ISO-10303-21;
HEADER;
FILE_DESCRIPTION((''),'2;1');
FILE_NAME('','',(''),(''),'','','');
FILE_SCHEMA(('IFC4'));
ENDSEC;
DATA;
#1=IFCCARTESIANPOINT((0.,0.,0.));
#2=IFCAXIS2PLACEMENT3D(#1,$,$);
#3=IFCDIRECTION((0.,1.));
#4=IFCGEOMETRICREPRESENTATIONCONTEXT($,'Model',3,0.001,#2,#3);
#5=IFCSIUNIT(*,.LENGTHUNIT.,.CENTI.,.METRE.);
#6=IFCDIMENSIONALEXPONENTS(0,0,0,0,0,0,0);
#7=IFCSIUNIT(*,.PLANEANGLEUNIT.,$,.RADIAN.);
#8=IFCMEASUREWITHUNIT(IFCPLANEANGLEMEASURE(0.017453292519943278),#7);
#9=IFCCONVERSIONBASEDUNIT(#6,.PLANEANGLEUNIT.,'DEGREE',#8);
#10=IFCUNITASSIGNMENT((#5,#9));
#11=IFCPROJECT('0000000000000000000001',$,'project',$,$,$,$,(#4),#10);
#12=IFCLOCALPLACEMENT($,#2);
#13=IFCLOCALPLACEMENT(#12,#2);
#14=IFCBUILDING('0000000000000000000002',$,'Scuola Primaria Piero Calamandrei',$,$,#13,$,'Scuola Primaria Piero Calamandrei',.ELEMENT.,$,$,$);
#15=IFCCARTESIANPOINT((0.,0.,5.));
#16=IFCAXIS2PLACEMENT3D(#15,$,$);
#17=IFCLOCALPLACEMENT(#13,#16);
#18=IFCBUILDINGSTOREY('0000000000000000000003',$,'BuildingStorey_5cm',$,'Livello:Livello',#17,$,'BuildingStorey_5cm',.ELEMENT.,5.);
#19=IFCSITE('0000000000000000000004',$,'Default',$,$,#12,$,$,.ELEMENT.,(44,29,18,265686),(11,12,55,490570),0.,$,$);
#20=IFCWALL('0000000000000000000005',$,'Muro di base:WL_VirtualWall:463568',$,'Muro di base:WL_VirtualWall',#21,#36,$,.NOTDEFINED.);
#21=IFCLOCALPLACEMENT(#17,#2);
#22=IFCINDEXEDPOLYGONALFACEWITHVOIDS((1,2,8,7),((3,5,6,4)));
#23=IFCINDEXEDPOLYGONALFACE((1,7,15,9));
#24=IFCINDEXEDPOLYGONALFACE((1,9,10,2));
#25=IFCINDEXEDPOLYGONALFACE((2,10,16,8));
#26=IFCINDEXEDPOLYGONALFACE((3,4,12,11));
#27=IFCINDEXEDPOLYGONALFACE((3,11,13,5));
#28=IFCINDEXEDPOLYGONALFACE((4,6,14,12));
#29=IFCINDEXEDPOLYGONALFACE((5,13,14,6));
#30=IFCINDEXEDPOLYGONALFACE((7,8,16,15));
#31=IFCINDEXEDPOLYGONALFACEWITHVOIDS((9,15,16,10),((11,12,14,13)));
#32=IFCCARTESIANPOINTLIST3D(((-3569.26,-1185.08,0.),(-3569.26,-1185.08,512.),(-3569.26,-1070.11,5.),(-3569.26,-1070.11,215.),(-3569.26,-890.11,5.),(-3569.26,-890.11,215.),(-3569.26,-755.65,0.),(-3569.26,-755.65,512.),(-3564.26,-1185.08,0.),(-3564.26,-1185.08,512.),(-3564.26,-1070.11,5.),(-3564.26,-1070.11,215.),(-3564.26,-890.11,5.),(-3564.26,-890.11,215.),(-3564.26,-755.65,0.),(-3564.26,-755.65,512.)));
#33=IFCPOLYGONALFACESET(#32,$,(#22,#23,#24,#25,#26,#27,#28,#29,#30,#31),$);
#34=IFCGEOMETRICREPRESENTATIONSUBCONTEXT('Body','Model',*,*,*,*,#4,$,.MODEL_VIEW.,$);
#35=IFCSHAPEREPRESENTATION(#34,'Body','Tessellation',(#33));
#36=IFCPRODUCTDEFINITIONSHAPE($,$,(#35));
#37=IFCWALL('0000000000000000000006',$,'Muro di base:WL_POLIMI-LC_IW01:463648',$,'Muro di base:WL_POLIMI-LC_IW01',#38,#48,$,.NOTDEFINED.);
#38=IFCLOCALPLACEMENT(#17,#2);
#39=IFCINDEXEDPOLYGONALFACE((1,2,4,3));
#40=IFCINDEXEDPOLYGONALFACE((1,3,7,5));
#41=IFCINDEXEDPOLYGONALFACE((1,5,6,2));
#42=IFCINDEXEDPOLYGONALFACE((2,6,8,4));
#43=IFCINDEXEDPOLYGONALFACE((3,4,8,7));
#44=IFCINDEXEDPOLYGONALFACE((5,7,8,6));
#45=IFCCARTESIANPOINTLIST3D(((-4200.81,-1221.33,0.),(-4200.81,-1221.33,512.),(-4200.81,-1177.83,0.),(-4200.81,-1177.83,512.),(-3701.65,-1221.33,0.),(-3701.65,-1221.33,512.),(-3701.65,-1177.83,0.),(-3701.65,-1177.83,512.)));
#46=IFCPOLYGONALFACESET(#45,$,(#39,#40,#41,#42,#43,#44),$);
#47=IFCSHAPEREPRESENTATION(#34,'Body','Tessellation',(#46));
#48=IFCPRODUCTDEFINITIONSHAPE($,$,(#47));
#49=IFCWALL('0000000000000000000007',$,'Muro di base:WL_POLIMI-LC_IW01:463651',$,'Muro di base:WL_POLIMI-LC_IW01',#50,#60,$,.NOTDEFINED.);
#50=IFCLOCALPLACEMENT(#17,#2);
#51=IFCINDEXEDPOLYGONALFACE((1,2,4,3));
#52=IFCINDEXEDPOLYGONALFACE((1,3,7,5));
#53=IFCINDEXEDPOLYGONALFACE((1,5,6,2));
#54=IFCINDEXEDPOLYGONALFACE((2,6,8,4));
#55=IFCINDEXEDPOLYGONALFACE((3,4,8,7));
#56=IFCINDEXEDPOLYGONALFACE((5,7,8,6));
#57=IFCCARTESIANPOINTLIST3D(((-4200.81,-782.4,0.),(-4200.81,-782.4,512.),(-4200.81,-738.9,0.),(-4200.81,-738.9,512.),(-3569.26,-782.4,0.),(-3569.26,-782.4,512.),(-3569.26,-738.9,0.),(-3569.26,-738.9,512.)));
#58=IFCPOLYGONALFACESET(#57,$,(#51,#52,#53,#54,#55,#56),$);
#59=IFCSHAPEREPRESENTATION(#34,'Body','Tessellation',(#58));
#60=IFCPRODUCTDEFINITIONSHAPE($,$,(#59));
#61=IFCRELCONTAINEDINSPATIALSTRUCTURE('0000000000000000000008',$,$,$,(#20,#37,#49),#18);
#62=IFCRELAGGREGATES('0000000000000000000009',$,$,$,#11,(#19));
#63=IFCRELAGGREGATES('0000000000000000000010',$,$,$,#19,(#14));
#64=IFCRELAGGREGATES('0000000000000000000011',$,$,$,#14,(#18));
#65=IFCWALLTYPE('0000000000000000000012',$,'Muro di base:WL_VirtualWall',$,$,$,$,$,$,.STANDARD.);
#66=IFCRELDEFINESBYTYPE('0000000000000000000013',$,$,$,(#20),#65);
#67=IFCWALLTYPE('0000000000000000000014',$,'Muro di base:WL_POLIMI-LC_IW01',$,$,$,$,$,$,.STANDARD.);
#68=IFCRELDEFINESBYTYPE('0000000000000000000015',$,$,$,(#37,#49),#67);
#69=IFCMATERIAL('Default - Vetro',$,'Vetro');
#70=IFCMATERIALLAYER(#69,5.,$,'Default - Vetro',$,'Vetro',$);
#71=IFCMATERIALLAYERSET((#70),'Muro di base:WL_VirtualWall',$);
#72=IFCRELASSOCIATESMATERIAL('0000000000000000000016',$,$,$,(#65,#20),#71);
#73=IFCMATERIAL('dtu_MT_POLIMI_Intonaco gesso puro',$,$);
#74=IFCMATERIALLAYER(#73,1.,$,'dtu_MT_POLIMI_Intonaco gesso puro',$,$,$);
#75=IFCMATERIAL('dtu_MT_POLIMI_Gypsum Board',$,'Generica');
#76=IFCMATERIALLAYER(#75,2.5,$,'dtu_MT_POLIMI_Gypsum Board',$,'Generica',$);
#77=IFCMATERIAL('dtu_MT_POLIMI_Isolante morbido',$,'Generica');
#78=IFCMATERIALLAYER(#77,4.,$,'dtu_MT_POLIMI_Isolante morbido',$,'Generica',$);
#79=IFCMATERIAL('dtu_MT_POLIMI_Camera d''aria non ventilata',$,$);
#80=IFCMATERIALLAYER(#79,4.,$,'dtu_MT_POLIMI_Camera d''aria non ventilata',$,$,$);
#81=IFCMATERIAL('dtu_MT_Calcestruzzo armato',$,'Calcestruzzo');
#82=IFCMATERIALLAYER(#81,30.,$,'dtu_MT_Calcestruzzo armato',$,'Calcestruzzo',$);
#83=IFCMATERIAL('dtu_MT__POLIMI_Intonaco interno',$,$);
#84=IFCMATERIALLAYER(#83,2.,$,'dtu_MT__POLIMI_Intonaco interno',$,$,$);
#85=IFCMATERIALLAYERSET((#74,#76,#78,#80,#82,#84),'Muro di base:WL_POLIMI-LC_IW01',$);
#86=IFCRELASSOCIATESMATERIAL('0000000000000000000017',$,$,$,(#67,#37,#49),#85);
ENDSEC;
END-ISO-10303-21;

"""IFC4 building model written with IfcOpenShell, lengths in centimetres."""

from ifc_helpers import new_model, entity, si_unit, converted_unit, direction, frame, frame_2d, origin, place, context, subcontext, project, spatial, rectangle, extrude, material, layer, layer_set, layer_usage, type_object, element, save


model = new_model("IFC4")

# Units and contexts
model_context = context("Model", 3, precision=0.001, world=origin(), true_north=direction((0.0, 1.0)))
body_context = subcontext(model_context, "Body", "Model", "MODEL_VIEW")
ifc_project = project(units=[si_unit("LENGTHUNIT", "METRE", prefix="CENTI"), converted_unit("PLANEANGLEUNIT", "DEGREE", entity("IfcPlaneAngleMeasure", 0.017453292519943278), si_unit("PLANEANGLEUNIT", "RADIAN"), dimensions=[0, 0, 0, 0, 0, 0, 0])], contexts=[model_context])

# Site, building, storey
site_placement = place(None, origin())
site = spatial("IfcSite", under=ifc_project, at=site_placement, Name="Default", CompositionType="ELEMENT", RefLatitude=(44, 29, 18, 265686), RefLongitude=(11, 12, 55, 490570), RefElevation=0.0)
building_placement = place(site_placement, origin())
building = spatial("IfcBuilding", under=site, at=building_placement, Name="Scuola Primaria Piero Calamandrei", LongName="Scuola Primaria Piero Calamandrei", CompositionType="ELEMENT")
storey_placement = place(building_placement, frame((0.0, 0.0, 5.0)))
storey = spatial("IfcBuildingStorey", under=building, at=storey_placement, Name="BuildingStorey_5cm", ObjectType="Livello:Livello", LongName="BuildingStorey_5cm", CompositionType="ELEMENT", Elevation=5.0)

# Shared definitions
ifc_material_1 = material(Name="dtu_MT__POLIMI_Intonaco interno")

# Shared definitions
ifc_material_2 = material(Name="dtu_MT_POLIMI_Intonaco gesso puro")

# Shared definitions
ifc_material_3 = material(Name="Default - Vetro", Category="Vetro")

# Shared definitions
ifc_material_4 = material(Name="dtu_MT_POLIMI_Isolante morbido", Category="Generica")
ifc_material_5 = material(Name="dtu_MT_POLIMI_Gypsum Board", Category="Generica")
ifc_material_6 = material(Name="dtu_MT_POLIMI_Camera d'aria non ventilata")

# Wall, opening
ifc_layer_1 = layer(ifc_material_3, 5.0, Name="Default - Vetro", Category="Vetro")
ifc_layer_set_1 = layer_set([ifc_layer_1], Name="Muro di base:WL_VirtualWall")
ifc_layer_usage_1 = layer_usage(ifc_layer_set_1, "AXIS2", "NEGATIVE", 2.5)
wall_type_1 = type_object("IfcWallType", Name="Muro di base:WL_VirtualWall", PredefinedType="STANDARD", material=ifc_layer_set_1)
wall_1_placement = place(storey_placement, frame((-3566.76, -1185.08, 0.0), z_axis=(0.0, 0.0, 1.0), x_axis=(0.0, 1.0, 0.0)))
wall_1 = element("IfcWall", 1, at=wall_1_placement, inside=storey, type_object=wall_type_1, material=ifc_layer_usage_1, Name="Muro di base:WL_VirtualWall:463568", ObjectType="Muro di base:WL_VirtualWall", PredefinedType="NOTDEFINED", context=body_context, shape_type="SweptSolid", body=[
    extrude(rectangle(XDim=429.42, YDim=5.0, at=frame_2d((214.71, 0.0), x_axis=(-1.0, 0.0))), origin(), (0.0, 0.0, 1.0), 512.0),
])
opening_1_placement = place(wall_1_placement, frame((114.96, -2.5, 5.0)))
element("IfcOpeningElement", 2, at=opening_1_placement, cuts=wall_1, PredefinedType="OPENING", context=body_context, shape_type="SweptSolid", body=[
    extrude(rectangle(XDim=210.0, YDim=180.0, at=frame_2d((105.0, 90.0), x_axis=(1.0, 0.0))), frame((0.0, 0.0, 0.0), z_axis=(0.0, 1.0, 0.0), x_axis=(0.0, 0.0, 1.0)), (0.0, 0.0, 1.0), 5.0),
])

# Walls
ifc_layer_2 = layer(ifc_material_2, 1.0, Name="dtu_MT_POLIMI_Intonaco gesso puro")
ifc_layer_3 = layer(ifc_material_5, 2.5, Name="dtu_MT_POLIMI_Gypsum Board", Category="Generica")
ifc_layer_4 = layer(ifc_material_4, 4.0, Name="dtu_MT_POLIMI_Isolante morbido", Category="Generica")
ifc_layer_5 = layer(ifc_material_6, 4.0, Name="dtu_MT_POLIMI_Camera d'aria non ventilata")
ifc_material_7 = material(Name="dtu_MT_Calcestruzzo armato", Category="Calcestruzzo")
ifc_layer_6 = layer(ifc_material_7, 30.0, Name="dtu_MT_Calcestruzzo armato", Category="Calcestruzzo")
ifc_layer_7 = layer(ifc_material_1, 2.0, Name="dtu_MT__POLIMI_Intonaco interno")
ifc_layer_set_2 = layer_set([ifc_layer_2, ifc_layer_3, ifc_layer_4, ifc_layer_5, ifc_layer_6, ifc_layer_7], Name="Muro di base:WL_POLIMI-LC_IW01")
ifc_layer_usage_2 = layer_usage(ifc_layer_set_2, "AXIS2", "NEGATIVE", 21.75)
wall_type_2 = type_object("IfcWallType", Name="Muro di base:WL_POLIMI-LC_IW01", PredefinedType="STANDARD", material=ifc_layer_set_2)
wall_2_placement = place(storey_placement, frame((-4200.81, -1199.58, 0.0)))
element("IfcWall", 3, at=wall_2_placement, inside=storey, type_object=wall_type_2, material=ifc_layer_usage_2, Name="Muro di base:WL_POLIMI-LC_IW01:463648", ObjectType="Muro di base:WL_POLIMI-LC_IW01", PredefinedType="NOTDEFINED", context=body_context, shape_type="SweptSolid", body=[
    extrude(rectangle(XDim=499.16, YDim=43.5, at=frame_2d((249.58, 0.0), x_axis=(-1.0, 0.0))), origin(), (0.0, 0.0, 1.0), 512.0),
])
ifc_layer_usage_3 = layer_usage(ifc_layer_set_2, "AXIS2", "NEGATIVE", 21.75)
wall_3_placement = place(storey_placement, frame((-4200.81, -760.65, 0.0)))
element("IfcWall", 4, at=wall_3_placement, inside=storey, type_object=wall_type_2, material=ifc_layer_usage_3, Name="Muro di base:WL_POLIMI-LC_IW01:463651", ObjectType="Muro di base:WL_POLIMI-LC_IW01", PredefinedType="NOTDEFINED", context=body_context, shape_type="SweptSolid", body=[
    extrude(rectangle(XDim=631.55, YDim=43.5, at=frame_2d((315.78, 0.0), x_axis=(-1.0, 0.0))), origin(), (0.0, 0.0, 1.0), 512.0),
])

save(model, "model.ifc")
